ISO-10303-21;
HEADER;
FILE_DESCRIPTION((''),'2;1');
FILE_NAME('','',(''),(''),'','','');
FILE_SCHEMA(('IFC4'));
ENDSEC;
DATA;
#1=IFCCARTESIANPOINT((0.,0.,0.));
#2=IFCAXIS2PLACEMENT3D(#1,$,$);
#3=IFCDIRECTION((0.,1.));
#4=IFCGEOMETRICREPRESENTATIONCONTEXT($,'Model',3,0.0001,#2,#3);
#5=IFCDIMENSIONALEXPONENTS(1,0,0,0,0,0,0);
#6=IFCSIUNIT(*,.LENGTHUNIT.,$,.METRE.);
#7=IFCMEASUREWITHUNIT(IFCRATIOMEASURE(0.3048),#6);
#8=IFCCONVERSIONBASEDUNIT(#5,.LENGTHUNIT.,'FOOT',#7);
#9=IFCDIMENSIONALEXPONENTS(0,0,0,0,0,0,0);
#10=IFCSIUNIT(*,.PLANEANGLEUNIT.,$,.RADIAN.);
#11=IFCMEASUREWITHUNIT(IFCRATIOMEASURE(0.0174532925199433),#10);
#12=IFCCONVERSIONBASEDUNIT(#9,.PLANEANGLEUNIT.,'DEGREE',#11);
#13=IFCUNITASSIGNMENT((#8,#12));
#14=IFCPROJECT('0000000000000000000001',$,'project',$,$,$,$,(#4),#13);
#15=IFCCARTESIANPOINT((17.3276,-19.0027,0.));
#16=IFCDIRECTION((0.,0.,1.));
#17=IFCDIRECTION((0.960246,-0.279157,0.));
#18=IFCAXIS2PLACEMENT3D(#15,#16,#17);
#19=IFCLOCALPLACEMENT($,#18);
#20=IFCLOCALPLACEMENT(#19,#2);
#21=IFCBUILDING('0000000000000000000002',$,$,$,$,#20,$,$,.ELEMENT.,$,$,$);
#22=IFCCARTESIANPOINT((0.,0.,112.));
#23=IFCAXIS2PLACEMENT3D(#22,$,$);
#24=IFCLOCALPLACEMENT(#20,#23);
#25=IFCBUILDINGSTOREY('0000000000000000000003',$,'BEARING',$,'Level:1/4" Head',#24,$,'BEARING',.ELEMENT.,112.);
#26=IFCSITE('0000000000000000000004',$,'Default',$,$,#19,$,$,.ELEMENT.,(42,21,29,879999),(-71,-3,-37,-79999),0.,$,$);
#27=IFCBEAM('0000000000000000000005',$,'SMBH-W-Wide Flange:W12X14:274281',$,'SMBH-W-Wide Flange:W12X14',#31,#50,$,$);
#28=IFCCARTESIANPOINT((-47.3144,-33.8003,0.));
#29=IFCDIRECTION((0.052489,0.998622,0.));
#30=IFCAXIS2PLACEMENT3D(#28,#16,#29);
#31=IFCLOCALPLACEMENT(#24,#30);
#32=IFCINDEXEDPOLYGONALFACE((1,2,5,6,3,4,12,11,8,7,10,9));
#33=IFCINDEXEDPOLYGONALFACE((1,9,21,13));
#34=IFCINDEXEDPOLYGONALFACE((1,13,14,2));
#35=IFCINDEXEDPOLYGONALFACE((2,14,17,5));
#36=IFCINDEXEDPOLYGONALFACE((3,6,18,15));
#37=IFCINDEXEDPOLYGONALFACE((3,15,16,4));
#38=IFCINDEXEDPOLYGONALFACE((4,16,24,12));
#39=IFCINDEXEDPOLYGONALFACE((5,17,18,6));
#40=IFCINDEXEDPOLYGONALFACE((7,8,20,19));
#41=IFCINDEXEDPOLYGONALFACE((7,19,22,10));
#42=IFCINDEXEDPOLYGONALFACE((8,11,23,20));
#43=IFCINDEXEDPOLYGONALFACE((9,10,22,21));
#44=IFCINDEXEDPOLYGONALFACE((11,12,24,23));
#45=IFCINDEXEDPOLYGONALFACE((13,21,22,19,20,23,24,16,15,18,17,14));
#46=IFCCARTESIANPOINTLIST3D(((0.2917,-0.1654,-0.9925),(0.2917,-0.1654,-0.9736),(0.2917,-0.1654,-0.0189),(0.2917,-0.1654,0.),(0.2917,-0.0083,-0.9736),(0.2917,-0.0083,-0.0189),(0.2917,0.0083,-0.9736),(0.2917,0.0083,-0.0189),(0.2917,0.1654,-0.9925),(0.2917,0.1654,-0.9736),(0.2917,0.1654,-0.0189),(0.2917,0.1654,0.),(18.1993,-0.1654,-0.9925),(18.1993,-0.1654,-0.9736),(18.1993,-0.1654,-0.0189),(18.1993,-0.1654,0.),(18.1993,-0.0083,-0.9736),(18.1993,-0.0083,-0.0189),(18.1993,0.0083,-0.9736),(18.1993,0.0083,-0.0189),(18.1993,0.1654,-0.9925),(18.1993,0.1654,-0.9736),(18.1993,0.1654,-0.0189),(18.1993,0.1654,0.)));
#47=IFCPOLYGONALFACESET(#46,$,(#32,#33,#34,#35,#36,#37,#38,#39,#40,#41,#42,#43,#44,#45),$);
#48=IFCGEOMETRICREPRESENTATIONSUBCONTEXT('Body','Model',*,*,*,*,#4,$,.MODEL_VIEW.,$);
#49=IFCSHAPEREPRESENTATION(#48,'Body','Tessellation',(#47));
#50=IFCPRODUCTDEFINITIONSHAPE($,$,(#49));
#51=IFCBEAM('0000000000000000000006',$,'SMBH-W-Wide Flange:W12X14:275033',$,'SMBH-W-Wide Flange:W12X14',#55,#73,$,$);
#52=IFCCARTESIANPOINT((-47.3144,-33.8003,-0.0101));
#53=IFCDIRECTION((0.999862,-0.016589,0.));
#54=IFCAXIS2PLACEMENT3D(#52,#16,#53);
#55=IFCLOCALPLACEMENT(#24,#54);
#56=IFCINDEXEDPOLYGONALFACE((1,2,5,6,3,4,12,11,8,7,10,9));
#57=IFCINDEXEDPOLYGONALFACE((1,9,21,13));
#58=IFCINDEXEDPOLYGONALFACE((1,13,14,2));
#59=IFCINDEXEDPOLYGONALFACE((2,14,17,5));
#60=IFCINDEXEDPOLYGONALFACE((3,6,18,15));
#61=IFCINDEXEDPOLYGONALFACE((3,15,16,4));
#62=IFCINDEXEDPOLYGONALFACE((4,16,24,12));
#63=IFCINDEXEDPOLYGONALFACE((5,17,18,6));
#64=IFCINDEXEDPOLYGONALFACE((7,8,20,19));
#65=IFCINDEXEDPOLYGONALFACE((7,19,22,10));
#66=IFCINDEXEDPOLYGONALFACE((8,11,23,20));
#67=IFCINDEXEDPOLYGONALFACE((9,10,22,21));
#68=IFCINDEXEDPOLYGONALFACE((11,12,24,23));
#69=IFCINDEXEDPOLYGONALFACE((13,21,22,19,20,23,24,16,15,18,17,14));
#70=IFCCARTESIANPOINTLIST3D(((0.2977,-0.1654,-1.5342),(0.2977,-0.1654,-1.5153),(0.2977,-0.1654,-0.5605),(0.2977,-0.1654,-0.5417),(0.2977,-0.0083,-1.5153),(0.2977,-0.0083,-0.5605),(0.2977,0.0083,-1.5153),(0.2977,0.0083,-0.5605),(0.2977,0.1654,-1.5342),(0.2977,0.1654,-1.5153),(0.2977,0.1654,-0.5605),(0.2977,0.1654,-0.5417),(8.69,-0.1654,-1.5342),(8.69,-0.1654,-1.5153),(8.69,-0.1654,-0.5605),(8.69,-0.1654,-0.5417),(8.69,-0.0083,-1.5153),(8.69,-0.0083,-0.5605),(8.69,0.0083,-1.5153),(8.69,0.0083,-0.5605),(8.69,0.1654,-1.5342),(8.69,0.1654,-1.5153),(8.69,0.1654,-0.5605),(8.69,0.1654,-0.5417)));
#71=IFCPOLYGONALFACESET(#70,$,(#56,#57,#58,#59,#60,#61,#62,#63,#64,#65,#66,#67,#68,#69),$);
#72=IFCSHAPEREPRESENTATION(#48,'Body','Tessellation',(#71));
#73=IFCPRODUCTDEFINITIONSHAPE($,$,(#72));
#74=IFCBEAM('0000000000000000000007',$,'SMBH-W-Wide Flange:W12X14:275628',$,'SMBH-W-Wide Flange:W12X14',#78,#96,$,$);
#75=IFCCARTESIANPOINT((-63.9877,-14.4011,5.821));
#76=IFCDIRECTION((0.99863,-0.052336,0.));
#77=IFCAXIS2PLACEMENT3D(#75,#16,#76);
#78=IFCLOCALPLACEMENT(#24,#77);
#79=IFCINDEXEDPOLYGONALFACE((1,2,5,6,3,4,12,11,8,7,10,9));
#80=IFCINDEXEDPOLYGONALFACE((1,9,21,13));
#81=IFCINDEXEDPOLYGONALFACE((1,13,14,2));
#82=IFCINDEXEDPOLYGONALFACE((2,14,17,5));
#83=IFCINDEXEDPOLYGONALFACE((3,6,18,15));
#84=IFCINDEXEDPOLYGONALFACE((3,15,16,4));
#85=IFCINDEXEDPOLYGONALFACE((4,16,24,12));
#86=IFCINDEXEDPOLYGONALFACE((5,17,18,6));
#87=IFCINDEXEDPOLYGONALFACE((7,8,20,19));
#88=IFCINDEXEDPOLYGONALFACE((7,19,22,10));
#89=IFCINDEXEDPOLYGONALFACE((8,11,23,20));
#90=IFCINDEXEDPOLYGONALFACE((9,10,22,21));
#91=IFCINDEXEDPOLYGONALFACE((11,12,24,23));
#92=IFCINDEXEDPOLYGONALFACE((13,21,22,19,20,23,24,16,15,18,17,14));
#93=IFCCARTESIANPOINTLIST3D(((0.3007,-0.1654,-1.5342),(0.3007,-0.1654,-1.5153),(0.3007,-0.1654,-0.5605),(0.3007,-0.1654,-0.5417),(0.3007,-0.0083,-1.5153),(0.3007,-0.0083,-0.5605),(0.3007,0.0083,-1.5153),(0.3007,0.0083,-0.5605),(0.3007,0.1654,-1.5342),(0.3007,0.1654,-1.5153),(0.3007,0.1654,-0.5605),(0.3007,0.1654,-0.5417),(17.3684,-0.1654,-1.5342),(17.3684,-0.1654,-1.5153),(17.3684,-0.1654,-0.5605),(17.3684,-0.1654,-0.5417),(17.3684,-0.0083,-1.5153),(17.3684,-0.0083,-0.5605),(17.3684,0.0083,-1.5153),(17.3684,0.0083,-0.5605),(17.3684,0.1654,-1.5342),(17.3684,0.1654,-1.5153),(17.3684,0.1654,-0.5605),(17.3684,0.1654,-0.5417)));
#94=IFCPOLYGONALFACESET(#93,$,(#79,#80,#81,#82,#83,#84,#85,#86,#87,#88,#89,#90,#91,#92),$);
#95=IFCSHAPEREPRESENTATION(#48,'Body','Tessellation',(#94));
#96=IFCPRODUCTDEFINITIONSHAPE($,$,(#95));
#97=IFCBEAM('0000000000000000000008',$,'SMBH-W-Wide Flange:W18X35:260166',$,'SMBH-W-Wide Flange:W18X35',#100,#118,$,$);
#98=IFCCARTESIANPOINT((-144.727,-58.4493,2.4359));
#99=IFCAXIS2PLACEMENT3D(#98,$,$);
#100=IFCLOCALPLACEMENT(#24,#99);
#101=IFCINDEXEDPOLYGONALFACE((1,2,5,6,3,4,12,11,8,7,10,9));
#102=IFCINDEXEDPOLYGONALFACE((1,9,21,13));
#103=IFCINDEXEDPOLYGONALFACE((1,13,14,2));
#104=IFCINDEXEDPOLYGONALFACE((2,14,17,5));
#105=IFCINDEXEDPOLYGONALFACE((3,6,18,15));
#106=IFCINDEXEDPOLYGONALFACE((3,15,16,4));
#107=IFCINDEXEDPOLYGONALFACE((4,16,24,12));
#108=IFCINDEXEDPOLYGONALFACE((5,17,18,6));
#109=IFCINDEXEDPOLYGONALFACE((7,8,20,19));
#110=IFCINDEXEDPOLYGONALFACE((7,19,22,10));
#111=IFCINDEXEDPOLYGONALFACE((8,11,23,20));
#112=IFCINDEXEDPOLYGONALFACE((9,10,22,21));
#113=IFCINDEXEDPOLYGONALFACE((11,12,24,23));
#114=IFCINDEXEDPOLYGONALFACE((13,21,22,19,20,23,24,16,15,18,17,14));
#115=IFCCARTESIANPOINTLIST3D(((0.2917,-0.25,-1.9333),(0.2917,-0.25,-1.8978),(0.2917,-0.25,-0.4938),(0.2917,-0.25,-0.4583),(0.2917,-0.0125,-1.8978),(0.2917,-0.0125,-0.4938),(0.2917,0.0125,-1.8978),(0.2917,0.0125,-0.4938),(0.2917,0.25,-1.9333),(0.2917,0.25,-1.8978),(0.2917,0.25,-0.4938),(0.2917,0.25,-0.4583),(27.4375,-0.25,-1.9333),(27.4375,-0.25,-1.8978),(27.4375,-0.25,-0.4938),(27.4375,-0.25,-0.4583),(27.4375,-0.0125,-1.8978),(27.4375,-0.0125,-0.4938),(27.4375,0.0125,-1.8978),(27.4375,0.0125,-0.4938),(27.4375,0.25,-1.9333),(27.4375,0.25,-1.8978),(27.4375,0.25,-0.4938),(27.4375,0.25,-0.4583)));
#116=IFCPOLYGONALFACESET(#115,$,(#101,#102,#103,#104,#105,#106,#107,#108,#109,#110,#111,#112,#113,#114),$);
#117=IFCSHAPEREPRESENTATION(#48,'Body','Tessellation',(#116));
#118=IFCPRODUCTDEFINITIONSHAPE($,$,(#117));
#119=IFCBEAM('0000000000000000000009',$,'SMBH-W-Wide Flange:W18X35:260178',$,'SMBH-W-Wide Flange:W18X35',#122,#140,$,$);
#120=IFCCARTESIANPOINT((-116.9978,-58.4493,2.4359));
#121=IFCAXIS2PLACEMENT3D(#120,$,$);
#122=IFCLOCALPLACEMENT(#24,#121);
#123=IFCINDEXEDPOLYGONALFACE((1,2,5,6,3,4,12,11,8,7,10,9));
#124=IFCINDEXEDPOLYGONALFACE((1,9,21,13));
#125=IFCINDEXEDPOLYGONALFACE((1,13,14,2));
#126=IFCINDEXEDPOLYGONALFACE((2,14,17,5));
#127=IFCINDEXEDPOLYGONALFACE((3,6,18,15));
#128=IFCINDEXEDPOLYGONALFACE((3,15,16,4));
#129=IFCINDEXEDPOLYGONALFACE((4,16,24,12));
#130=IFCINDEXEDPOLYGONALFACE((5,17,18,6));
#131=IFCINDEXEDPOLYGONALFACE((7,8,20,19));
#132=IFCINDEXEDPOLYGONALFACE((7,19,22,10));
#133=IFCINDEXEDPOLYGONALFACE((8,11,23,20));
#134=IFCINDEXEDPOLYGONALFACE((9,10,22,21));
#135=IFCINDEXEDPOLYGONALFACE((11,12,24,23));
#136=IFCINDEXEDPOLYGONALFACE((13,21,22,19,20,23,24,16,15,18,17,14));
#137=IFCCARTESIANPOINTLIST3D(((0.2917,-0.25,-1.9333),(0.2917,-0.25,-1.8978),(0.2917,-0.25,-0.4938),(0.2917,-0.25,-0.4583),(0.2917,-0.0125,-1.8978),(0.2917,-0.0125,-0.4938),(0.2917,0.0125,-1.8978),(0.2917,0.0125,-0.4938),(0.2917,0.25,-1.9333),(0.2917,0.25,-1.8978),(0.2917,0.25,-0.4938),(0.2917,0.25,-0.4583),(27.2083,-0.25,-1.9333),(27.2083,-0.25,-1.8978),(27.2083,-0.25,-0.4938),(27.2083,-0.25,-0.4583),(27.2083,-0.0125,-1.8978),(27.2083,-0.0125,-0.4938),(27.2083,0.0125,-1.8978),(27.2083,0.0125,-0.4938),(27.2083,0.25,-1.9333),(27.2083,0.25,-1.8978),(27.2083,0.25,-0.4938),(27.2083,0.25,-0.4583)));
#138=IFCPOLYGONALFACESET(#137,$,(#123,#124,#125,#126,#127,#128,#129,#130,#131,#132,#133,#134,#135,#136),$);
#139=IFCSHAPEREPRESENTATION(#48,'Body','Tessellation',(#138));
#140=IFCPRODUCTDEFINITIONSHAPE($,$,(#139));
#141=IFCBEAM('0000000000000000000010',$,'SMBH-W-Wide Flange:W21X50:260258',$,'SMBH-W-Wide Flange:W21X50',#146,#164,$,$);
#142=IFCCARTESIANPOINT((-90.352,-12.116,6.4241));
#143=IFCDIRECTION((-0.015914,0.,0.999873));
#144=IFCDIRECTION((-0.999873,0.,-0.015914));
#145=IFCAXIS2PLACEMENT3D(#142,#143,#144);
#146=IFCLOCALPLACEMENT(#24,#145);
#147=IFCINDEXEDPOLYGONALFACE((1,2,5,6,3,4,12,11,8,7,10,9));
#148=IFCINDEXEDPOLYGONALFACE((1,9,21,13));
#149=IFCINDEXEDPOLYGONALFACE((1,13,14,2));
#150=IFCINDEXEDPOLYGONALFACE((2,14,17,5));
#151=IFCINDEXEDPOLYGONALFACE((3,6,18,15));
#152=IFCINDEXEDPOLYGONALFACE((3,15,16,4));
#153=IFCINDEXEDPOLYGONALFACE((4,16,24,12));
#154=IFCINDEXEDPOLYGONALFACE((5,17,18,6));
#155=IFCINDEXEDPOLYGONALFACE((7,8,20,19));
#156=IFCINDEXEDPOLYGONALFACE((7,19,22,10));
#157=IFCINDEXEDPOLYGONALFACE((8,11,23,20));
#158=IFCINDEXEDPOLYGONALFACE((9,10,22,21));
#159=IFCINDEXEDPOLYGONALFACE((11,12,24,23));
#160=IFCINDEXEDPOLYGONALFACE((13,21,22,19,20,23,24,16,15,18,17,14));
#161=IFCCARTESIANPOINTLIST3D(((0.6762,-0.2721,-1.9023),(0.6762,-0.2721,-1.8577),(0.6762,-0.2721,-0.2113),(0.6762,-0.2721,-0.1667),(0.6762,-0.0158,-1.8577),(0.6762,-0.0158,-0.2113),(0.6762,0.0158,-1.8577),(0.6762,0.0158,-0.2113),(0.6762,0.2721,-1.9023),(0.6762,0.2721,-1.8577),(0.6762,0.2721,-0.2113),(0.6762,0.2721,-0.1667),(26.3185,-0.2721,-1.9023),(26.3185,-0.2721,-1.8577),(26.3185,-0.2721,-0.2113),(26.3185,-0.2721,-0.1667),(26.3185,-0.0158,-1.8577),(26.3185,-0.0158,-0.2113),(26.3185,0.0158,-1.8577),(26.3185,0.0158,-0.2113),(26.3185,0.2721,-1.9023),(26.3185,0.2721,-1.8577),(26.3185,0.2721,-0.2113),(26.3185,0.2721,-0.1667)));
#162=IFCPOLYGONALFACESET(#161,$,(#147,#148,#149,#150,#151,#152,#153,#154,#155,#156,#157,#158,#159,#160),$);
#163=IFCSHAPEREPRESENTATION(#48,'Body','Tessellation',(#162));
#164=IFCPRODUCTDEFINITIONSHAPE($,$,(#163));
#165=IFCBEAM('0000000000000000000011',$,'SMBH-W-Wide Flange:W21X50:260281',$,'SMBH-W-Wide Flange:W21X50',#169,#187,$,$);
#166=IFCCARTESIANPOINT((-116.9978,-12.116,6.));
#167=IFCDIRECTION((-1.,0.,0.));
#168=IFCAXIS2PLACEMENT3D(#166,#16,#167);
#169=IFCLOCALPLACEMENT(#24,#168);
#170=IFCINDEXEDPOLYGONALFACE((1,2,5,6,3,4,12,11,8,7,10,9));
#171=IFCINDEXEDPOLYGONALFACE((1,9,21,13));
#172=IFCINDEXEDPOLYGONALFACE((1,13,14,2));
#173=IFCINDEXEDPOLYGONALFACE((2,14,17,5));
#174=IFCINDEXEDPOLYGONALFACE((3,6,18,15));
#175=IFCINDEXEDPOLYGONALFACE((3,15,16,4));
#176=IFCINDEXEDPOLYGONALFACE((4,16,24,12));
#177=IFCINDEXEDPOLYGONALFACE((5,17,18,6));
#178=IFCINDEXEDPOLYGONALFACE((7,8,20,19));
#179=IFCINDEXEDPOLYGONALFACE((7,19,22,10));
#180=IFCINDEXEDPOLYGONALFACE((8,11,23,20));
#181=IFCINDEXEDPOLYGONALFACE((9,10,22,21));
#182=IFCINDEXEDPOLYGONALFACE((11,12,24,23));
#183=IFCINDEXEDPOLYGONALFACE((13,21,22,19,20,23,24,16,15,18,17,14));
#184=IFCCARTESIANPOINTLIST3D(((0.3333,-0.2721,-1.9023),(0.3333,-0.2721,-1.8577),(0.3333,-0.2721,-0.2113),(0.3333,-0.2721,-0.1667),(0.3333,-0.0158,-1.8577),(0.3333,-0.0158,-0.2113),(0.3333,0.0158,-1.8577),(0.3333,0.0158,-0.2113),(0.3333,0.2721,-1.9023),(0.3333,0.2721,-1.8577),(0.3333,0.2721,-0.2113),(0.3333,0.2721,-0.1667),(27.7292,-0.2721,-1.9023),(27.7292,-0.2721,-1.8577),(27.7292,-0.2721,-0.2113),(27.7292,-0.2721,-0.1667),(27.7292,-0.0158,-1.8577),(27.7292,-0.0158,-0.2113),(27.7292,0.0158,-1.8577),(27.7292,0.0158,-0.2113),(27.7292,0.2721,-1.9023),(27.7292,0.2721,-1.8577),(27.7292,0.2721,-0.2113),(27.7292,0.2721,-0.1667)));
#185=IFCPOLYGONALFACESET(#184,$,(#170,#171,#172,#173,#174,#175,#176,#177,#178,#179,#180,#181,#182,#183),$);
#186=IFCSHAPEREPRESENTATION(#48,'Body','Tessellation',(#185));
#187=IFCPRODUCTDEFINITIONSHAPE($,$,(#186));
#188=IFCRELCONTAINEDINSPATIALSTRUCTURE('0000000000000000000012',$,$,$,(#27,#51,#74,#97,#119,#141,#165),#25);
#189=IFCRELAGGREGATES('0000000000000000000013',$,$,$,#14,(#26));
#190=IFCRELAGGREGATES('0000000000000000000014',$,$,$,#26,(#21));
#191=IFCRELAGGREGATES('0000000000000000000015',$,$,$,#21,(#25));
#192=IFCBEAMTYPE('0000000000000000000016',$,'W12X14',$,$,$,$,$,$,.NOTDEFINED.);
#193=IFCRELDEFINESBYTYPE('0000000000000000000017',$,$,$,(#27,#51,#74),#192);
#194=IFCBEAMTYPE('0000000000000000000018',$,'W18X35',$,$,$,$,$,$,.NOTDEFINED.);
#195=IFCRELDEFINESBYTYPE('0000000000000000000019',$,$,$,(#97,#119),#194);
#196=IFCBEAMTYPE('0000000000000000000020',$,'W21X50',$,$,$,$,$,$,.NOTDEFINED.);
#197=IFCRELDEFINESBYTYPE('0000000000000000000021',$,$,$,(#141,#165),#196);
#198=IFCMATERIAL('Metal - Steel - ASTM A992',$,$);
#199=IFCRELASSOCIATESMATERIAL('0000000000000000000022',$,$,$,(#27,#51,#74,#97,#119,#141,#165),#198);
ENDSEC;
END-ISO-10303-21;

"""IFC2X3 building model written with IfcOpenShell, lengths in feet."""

from ifc_helpers import new_model, entity, si_unit, converted_unit, direction, frame, frame_2d, origin, place, context, subcontext, project, spatial, i_section, extrude, material, type_object, element, save


model = new_model("IFC2X3")

# Units and contexts
model_context = context("Model", 3, precision=0.0001, world=origin(), true_north=direction((0.0, 1.0)))
body_context = subcontext(model_context, "Body", "Model", "MODEL_VIEW")
ifc_project = project(units=[converted_unit("LENGTHUNIT", "FOOT", entity("IfcRatioMeasure", 0.3048), si_unit("LENGTHUNIT", "METRE"), dimensions=[1, 0, 0, 0, 0, 0, 0]), converted_unit("PLANEANGLEUNIT", "DEGREE", entity("IfcRatioMeasure", 0.0174532925199433), si_unit("PLANEANGLEUNIT", "RADIAN"), dimensions=[0, 0, 0, 0, 0, 0, 0])], contexts=[model_context])

# Site, building, storey
site_placement = place(None, frame((17.3276, -19.0027, 0.0), z_axis=(0.0, 0.0, 1.0), x_axis=(0.960246, -0.279157, 0.0)))
site = spatial("IfcSite", under=ifc_project, at=site_placement, Name="Default", CompositionType="ELEMENT", RefLatitude=(42, 21, 29, 879999), RefLongitude=(-71, -3, -37, -79999), RefElevation=0.0)
building_placement = place(site_placement, origin())
building = spatial("IfcBuilding", under=site, at=building_placement, CompositionType="ELEMENT")
storey_placement = place(building_placement, frame((0.0, 0.0, 112.0)))
storey = spatial("IfcBuildingStorey", under=building, at=storey_placement, Name="BEARING", ObjectType="Level:1/4\" Head", LongName="BEARING", CompositionType="ELEMENT", Elevation=112.0)

# Beams
ifc_material_1 = material(Name="Metal - Steel - ASTM A992")
beam_type_1 = type_object("IfcBeamType", Name="W12X14", PredefinedType="NOTDEFINED")
beam_1_placement = place(storey_placement, frame((-47.3144, -33.8003, 0.0), z_axis=(0.0, 0.0, 1.0), x_axis=(0.052489, 0.998622, 0.0)))
element("IfcBeam", 1, at=beam_1_placement, inside=storey, type_object=beam_type_1, material=ifc_material_1, Name="SMBH-W-Wide Flange:W12X14:274281", ObjectType="SMBH-W-Wide Flange:W12X14", context=body_context, shape_type="SweptSolid", body=[
    extrude(i_section(OverallWidth=0.3307, OverallDepth=0.9925, WebThickness=0.0166, FlangeThickness=0.0189, at=frame_2d((0.0, 0.0), x_axis=(0.0, 1.0))), frame((0.2917, 0.0, -0.4963), z_axis=(1.0, 0.0, 0.0), x_axis=(0.0, 0.0, -1.0)), (0.0, 0.0, 1.0), 17.9076),
])
beam_2_placement = place(storey_placement, frame((-47.3144, -33.8003, -0.0101), z_axis=(0.0, 0.0, 1.0), x_axis=(0.999862, -0.016589, 0.0)))
element("IfcBeam", 2, at=beam_2_placement, inside=storey, type_object=beam_type_1, material=ifc_material_1, Name="SMBH-W-Wide Flange:W12X14:275033", ObjectType="SMBH-W-Wide Flange:W12X14", context=body_context, shape_type="SweptSolid", body=[
    extrude(i_section(OverallWidth=0.3307, OverallDepth=0.9925, WebThickness=0.0166, FlangeThickness=0.0189, at=frame_2d((0.0, 0.0), x_axis=(0.0, 1.0))), frame((0.2977, 0.0, -1.0379), z_axis=(1.0, 0.0, 0.0), x_axis=(0.0, 0.0, -1.0)), (0.0, 0.0, 1.0), 8.3922),
])
beam_3_placement = place(storey_placement, frame((-63.9877, -14.4011, 5.821), z_axis=(0.0, 0.0, 1.0), x_axis=(0.99863, -0.052336, 0.0)))
element("IfcBeam", 3, at=beam_3_placement, inside=storey, type_object=beam_type_1, material=ifc_material_1, Name="SMBH-W-Wide Flange:W12X14:275628", ObjectType="SMBH-W-Wide Flange:W12X14", context=body_context, shape_type="SweptSolid", body=[
    extrude(i_section(OverallWidth=0.3307, OverallDepth=0.9925, WebThickness=0.0166, FlangeThickness=0.0189, at=frame_2d((0.0, 0.0), x_axis=(0.0, 1.0))), frame((0.3007, 0.0, -1.0379), z_axis=(1.0, 0.0, 0.0), x_axis=(0.0, 0.0, -1.0)), (0.0, 0.0, 1.0), 17.0677),
])
beam_type_2 = type_object("IfcBeamType", Name="W18X35", PredefinedType="NOTDEFINED")
beam_4_placement = place(storey_placement, frame((-144.727, -58.4493, 2.4359)))
element("IfcBeam", 4, at=beam_4_placement, inside=storey, type_object=beam_type_2, material=ifc_material_1, Name="SMBH-W-Wide Flange:W18X35:260166", ObjectType="SMBH-W-Wide Flange:W18X35", context=body_context, shape_type="SweptSolid", body=[
    extrude(i_section(OverallWidth=0.5, OverallDepth=1.4749, WebThickness=0.0251, FlangeThickness=0.0355, at=frame_2d((0.0, 0.0), x_axis=(0.0, 1.0))), frame((0.2917, 0.0, -1.1958), z_axis=(1.0, 0.0, 0.0), x_axis=(0.0, 0.0, -1.0)), (0.0, 0.0, 1.0), 27.1458),
])
beam_5_placement = place(storey_placement, frame((-116.9978, -58.4493, 2.4359)))
element("IfcBeam", 5, at=beam_5_placement, inside=storey, type_object=beam_type_2, material=ifc_material_1, Name="SMBH-W-Wide Flange:W18X35:260178", ObjectType="SMBH-W-Wide Flange:W18X35", context=body_context, shape_type="SweptSolid", body=[
    extrude(i_section(OverallWidth=0.5, OverallDepth=1.4749, WebThickness=0.0251, FlangeThickness=0.0355, at=frame_2d((0.0, 0.0), x_axis=(0.0, 1.0))), frame((0.2917, 0.0, -1.1958), z_axis=(1.0, 0.0, 0.0), x_axis=(0.0, 0.0, -1.0)), (0.0, 0.0, 1.0), 26.9167),
])
beam_type_3 = type_object("IfcBeamType", Name="W21X50", PredefinedType="NOTDEFINED")
beam_6_placement = place(storey_placement, frame((-90.352, -12.116, 6.4241), z_axis=(-0.015914, 0.0, 0.999873), x_axis=(-0.999873, 0.0, -0.015914)))
element("IfcBeam", 6, at=beam_6_placement, inside=storey, type_object=beam_type_3, material=ifc_material_1, Name="SMBH-W-Wide Flange:W21X50:260258", ObjectType="SMBH-W-Wide Flange:W21X50", context=body_context, shape_type="SweptSolid", body=[
    extrude(i_section(OverallWidth=0.5443, OverallDepth=1.7357, WebThickness=0.0316, FlangeThickness=0.0446, at=frame_2d((0.0, 0.0), x_axis=(0.0, 1.0))), frame((0.6762, 0.0, -1.0345), z_axis=(1.0, 0.0, 0.0), x_axis=(0.0, 0.0, -1.0)), (0.0, 0.0, 1.0), 25.6423),
])
beam_7_placement = place(storey_placement, frame((-116.9978, -12.116, 6.0), z_axis=(0.0, 0.0, 1.0), x_axis=(-1.0, 0.0, 0.0)))
element("IfcBeam", 7, at=beam_7_placement, inside=storey, type_object=beam_type_3, material=ifc_material_1, Name="SMBH-W-Wide Flange:W21X50:260281", ObjectType="SMBH-W-Wide Flange:W21X50", context=body_context, shape_type="SweptSolid", body=[
    extrude(i_section(OverallWidth=0.5443, OverallDepth=1.7357, WebThickness=0.0316, FlangeThickness=0.0446, at=frame_2d((0.0, 0.0), x_axis=(0.0, 1.0))), frame((0.3333, 0.0, -1.0345), z_axis=(1.0, 0.0, 0.0), x_axis=(0.0, 0.0, -1.0)), (0.0, 0.0, 1.0), 27.3958),
])

save(model, "model.ifc")
